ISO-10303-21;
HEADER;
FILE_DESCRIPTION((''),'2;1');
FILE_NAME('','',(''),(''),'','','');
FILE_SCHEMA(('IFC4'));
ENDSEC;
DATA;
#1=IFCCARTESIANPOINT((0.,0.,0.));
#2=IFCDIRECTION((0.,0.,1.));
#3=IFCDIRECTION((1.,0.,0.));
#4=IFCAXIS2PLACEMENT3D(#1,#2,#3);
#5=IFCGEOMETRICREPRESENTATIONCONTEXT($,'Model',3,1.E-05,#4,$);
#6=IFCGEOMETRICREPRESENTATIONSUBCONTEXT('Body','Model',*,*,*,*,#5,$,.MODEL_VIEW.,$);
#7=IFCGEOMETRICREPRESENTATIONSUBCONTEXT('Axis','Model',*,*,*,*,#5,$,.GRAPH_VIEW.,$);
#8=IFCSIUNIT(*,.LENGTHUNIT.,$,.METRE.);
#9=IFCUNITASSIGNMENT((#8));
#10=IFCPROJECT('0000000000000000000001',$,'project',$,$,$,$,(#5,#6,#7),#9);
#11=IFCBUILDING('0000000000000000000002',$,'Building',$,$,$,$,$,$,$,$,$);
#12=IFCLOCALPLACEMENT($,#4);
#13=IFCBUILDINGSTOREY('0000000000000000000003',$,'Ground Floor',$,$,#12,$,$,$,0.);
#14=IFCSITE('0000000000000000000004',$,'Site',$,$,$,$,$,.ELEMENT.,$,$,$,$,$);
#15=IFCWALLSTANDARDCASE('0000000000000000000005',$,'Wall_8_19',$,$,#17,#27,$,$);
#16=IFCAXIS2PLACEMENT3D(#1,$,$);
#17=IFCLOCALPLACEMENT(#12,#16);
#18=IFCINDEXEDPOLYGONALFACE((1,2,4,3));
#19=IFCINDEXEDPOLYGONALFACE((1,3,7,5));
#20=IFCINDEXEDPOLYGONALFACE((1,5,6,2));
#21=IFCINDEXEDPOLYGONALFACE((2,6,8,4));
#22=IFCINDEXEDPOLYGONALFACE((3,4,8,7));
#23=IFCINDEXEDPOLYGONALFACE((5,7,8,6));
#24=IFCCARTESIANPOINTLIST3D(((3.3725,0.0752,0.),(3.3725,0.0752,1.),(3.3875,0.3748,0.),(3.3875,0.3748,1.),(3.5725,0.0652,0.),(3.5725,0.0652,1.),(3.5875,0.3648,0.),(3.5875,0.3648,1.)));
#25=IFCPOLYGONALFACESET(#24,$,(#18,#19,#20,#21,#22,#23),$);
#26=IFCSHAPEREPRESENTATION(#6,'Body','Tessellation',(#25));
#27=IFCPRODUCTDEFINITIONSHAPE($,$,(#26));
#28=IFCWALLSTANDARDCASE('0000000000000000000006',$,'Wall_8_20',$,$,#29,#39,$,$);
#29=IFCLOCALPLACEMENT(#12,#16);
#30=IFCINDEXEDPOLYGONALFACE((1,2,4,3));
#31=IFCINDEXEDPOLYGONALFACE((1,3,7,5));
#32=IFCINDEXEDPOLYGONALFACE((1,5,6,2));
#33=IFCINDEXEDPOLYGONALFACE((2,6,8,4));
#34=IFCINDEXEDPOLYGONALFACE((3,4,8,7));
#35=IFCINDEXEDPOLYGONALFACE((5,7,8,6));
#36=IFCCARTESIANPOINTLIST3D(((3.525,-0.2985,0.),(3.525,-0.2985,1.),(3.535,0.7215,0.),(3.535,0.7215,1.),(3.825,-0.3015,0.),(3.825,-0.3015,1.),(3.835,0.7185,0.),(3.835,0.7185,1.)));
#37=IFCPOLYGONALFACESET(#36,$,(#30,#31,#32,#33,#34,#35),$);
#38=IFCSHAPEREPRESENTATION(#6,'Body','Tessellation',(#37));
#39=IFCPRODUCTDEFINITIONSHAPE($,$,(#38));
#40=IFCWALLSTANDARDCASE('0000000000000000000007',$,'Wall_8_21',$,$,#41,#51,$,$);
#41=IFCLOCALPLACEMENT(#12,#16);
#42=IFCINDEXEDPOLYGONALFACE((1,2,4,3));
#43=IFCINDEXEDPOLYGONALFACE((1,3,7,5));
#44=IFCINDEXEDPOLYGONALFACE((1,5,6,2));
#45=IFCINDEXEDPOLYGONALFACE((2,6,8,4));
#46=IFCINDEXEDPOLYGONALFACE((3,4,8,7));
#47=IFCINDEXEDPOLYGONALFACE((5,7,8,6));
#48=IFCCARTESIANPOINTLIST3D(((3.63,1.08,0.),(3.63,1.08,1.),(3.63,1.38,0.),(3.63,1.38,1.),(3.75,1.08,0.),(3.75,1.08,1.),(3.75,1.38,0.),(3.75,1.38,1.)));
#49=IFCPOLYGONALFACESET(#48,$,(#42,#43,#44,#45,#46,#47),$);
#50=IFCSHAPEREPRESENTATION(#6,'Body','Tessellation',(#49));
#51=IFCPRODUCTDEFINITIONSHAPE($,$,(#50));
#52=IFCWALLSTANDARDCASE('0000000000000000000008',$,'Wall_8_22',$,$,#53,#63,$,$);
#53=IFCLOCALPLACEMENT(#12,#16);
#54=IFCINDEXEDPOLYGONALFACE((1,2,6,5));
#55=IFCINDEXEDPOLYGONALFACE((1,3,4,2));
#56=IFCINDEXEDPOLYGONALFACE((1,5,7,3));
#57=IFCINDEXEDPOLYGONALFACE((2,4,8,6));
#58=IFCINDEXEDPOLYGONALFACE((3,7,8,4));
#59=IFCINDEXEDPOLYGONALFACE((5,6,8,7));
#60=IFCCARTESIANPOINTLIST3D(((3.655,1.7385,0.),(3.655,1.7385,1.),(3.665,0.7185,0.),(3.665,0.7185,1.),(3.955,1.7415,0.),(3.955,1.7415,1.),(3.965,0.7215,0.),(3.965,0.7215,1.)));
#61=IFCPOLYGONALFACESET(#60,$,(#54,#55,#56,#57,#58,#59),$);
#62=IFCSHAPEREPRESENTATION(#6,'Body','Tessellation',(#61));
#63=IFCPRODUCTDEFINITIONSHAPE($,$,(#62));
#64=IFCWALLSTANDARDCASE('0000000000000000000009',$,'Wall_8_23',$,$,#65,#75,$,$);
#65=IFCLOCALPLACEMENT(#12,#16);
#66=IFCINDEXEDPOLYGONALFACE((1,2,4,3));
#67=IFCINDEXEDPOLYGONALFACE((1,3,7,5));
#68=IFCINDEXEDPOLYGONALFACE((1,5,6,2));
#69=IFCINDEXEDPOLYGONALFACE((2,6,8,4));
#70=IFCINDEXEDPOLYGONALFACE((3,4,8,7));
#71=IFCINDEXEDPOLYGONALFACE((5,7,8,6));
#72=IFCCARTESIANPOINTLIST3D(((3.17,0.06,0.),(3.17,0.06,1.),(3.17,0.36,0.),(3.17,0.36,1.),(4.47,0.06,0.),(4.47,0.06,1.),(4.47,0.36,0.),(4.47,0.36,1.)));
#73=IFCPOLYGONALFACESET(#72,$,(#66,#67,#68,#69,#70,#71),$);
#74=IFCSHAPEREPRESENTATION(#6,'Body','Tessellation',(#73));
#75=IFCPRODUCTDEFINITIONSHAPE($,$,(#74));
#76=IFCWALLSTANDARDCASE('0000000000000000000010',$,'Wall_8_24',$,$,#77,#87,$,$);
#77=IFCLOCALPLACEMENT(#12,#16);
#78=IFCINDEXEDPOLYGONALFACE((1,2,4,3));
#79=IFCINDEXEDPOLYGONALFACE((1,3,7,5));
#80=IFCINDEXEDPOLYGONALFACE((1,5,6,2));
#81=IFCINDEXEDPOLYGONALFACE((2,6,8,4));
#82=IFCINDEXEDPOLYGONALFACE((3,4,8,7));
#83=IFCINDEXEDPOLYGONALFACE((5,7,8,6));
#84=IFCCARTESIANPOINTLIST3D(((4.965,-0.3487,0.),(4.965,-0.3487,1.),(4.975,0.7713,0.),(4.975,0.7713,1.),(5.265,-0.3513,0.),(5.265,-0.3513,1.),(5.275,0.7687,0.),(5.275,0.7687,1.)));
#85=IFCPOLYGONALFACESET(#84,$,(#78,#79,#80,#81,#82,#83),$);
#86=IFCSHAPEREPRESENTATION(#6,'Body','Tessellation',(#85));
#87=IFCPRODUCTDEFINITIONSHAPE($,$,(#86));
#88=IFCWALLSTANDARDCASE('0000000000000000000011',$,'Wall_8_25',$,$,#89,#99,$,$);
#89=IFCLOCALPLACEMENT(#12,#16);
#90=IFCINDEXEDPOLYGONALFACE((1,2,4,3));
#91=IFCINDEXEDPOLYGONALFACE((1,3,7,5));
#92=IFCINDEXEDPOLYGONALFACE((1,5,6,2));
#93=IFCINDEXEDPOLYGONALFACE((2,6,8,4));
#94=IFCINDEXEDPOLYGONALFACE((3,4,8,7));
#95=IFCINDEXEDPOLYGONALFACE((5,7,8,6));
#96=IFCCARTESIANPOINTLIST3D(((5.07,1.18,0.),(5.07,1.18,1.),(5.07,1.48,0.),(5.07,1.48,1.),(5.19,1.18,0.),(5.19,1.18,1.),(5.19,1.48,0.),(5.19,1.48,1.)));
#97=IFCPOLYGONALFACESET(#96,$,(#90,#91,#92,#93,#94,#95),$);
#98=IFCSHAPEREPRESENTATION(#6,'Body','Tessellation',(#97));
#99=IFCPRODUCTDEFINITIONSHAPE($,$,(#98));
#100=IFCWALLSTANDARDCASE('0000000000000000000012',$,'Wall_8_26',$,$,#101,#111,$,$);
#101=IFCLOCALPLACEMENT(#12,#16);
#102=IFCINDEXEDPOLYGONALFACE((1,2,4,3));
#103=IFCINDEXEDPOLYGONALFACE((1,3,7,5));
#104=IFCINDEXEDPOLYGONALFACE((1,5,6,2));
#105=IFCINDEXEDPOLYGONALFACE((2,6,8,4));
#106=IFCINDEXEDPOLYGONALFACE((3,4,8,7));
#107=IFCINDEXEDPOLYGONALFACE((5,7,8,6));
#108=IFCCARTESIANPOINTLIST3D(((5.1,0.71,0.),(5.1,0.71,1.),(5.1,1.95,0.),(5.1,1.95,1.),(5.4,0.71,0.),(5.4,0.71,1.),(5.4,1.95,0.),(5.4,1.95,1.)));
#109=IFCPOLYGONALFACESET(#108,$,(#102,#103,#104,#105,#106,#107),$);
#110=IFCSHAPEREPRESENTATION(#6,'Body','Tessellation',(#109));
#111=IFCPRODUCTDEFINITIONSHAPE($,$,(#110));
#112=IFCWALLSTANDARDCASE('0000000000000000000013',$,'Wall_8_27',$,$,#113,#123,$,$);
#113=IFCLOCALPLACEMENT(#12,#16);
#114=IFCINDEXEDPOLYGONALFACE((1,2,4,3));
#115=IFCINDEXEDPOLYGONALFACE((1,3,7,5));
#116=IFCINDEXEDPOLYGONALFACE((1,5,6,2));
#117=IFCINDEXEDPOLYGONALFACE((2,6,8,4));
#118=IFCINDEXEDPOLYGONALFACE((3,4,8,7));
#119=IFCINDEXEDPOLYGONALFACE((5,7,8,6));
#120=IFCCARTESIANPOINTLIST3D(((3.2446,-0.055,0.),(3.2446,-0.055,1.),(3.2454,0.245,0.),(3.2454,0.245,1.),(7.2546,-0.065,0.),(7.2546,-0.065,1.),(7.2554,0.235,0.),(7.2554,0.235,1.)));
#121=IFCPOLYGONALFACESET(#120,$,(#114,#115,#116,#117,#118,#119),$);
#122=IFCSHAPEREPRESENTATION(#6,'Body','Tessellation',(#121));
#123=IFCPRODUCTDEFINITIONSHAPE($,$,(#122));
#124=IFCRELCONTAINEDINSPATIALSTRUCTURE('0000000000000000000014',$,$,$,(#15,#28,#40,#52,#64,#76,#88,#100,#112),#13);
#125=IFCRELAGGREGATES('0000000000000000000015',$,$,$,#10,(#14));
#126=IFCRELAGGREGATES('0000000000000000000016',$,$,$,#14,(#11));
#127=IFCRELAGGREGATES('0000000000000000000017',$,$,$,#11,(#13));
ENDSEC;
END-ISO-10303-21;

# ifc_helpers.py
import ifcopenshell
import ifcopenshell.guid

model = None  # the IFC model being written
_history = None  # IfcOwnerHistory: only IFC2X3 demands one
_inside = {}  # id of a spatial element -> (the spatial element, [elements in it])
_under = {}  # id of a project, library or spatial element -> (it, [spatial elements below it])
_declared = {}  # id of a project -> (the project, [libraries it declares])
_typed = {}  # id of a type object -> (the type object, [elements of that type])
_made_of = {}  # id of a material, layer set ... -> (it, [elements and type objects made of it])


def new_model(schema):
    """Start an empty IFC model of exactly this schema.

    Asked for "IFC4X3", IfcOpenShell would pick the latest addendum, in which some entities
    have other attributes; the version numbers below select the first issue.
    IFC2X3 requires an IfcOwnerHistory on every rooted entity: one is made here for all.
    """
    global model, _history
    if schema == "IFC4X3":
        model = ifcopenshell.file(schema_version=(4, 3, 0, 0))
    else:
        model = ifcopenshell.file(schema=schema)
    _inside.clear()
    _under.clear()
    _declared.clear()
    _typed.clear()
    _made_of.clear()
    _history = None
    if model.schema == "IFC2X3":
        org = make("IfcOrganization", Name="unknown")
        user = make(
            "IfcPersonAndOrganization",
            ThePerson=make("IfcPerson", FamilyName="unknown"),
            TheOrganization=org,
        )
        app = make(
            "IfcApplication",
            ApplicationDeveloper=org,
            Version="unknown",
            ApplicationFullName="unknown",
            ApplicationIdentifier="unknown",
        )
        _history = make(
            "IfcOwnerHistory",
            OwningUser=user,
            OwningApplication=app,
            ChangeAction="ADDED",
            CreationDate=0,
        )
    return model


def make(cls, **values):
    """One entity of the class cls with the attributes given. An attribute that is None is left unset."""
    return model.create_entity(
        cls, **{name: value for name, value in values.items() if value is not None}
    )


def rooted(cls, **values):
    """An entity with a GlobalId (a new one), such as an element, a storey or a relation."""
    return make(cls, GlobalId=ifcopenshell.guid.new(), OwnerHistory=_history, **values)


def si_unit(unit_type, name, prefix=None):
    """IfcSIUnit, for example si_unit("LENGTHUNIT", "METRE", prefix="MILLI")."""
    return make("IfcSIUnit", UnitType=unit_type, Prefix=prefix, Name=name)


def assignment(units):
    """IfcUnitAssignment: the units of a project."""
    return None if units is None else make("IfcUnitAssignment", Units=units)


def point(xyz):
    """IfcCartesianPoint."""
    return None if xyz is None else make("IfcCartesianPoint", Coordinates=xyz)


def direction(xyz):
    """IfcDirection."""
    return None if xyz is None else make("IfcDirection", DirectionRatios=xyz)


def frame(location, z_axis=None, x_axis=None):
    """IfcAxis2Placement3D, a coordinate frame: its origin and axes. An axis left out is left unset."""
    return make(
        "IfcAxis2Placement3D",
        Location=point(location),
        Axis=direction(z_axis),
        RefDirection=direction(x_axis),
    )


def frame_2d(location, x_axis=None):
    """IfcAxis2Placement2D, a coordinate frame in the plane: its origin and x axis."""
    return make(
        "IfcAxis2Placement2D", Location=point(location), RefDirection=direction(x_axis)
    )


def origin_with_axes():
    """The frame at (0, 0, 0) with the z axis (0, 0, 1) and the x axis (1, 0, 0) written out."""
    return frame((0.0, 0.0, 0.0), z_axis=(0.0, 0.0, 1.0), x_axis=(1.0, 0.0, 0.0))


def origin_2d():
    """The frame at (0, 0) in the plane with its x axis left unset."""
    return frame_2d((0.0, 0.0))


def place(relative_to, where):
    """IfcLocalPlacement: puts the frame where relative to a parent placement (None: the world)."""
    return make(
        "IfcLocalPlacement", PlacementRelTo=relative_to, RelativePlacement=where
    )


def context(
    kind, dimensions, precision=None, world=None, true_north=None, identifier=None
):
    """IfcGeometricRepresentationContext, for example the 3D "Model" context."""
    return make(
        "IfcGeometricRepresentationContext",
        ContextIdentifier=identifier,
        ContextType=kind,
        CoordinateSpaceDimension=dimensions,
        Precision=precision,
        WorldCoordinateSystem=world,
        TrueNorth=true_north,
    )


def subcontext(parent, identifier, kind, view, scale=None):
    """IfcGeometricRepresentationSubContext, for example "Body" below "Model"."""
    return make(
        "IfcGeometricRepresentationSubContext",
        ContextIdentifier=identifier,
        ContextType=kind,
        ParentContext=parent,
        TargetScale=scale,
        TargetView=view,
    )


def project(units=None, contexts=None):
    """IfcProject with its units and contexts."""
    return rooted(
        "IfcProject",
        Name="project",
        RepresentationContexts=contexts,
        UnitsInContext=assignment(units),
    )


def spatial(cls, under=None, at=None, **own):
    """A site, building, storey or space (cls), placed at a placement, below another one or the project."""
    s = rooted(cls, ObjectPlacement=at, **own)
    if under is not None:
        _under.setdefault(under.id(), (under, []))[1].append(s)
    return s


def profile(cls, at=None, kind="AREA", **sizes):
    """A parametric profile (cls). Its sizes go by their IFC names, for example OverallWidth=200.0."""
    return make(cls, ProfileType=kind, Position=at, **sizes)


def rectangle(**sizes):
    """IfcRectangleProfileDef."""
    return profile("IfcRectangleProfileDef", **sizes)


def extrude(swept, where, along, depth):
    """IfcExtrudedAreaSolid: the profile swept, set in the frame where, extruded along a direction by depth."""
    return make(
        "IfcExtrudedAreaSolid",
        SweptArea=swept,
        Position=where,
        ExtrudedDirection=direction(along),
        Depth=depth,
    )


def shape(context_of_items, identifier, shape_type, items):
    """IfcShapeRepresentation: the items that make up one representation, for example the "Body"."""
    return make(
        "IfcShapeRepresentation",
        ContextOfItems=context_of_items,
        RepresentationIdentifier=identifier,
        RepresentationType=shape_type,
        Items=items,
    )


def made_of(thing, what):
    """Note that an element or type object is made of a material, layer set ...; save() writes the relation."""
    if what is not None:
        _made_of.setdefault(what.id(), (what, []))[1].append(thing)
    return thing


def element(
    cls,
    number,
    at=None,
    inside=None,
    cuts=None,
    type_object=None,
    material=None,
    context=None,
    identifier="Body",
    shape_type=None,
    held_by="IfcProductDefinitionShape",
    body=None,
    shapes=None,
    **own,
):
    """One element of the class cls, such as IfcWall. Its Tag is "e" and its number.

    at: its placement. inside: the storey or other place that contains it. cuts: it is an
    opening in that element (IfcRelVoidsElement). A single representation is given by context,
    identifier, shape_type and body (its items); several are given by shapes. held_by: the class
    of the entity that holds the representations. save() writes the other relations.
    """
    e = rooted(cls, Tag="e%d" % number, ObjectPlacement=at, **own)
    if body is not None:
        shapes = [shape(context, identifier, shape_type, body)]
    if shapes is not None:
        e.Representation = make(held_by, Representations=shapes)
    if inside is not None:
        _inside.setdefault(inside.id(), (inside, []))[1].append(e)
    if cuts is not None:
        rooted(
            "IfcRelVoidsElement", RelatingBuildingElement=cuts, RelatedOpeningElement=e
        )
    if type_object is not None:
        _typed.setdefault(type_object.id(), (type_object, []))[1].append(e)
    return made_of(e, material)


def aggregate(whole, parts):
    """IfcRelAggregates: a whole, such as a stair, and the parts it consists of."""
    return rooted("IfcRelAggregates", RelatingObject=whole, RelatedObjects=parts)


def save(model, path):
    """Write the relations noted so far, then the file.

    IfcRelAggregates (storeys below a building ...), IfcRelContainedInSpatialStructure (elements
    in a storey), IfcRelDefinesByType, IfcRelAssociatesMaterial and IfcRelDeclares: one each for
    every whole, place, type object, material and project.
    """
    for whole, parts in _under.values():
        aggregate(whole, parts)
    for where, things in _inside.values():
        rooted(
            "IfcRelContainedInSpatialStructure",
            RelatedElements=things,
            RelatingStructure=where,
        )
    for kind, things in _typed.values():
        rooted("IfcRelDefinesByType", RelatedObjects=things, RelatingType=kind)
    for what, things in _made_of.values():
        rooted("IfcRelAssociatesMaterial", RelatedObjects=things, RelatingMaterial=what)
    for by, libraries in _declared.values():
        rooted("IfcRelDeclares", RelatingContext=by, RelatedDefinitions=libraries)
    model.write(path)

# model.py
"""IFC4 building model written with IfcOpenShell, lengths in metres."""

from ifc_helpers import new_model, si_unit, frame, origin_with_axes, origin_2d, place, context, subcontext, project, spatial, rectangle, extrude, element, save


model = new_model("IFC4")

# Units and contexts
model_context = context("Model", 3, precision=1e-05, world=origin_with_axes())
body_context = subcontext(model_context, "Body", "Model", "MODEL_VIEW")
axis_context = subcontext(model_context, "Axis", "Model", "GRAPH_VIEW")
ifc_project = project(units=[si_unit("LENGTHUNIT", "METRE")], contexts=[model_context, body_context, axis_context])

# Site, building, storey
site = spatial("IfcSite", under=ifc_project, Name="Site", CompositionType="ELEMENT")
building = spatial("IfcBuilding", under=site, Name="Building")
storey_placement = place(None, origin_with_axes())
storey = spatial("IfcBuildingStorey", under=building, at=storey_placement, Name="Ground Floor", Elevation=0.0)

# Walls
wall_1_placement = place(storey_placement, frame((3.48, 0.22, 0.0), z_axis=(0.0, 0.0, 1.0), x_axis=(0.998752, -0.049938, 0.0)))
element("IfcWallStandardCase", 1, at=wall_1_placement, inside=storey, Name="Wall_8_19", context=body_context, shape_type="SweptSolid", body=[
    extrude(rectangle(XDim=0.2002, YDim=0.3, at=origin_2d()), origin_with_axes(), (0.0, 0.0, 1.0), 1.0),
])
wall_2_placement = place(storey_placement, frame((3.68, 0.21, 0.0), z_axis=(0.0, 0.0, 1.0), x_axis=(0.009803, 0.999952, 0.0)))
element("IfcWallStandardCase", 2, at=wall_2_placement, inside=storey, Name="Wall_8_20", context=body_context, shape_type="SweptSolid", body=[
    extrude(rectangle(XDim=1.02, YDim=0.3, at=origin_2d()), origin_with_axes(), (0.0, 0.0, 1.0), 1.0),
])
wall_3_placement = place(storey_placement, frame((3.69, 1.23, 0.0), z_axis=(0.0, 0.0, 1.0), x_axis=(1.0, 0.0, 0.0)))
element("IfcWallStandardCase", 3, at=wall_3_placement, inside=storey, Name="Wall_8_21", context=body_context, shape_type="SweptSolid", body=[
    extrude(rectangle(XDim=0.12, YDim=0.3, at=origin_2d()), origin_with_axes(), (0.0, 0.0, 1.0), 1.0),
])
wall_4_placement = place(storey_placement, frame((3.81, 1.23, 0.0), z_axis=(0.0, 0.0, 1.0), x_axis=(0.009803, -0.999952, 0.0)))
element("IfcWallStandardCase", 4, at=wall_4_placement, inside=storey, Name="Wall_8_22", context=body_context, shape_type="SweptSolid", body=[
    extrude(rectangle(XDim=1.02, YDim=0.3, at=origin_2d()), origin_with_axes(), (0.0, 0.0, 1.0), 1.0),
])
wall_5_placement = place(storey_placement, frame((3.82, 0.21, 0.0), z_axis=(0.0, 0.0, 1.0), x_axis=(1.0, 0.0, 0.0)))
element("IfcWallStandardCase", 5, at=wall_5_placement, inside=storey, Name="Wall_8_23", context=body_context, shape_type="SweptSolid", body=[
    extrude(rectangle(XDim=1.3, YDim=0.3, at=origin_2d()), origin_with_axes(), (0.0, 0.0, 1.0), 1.0),
])
wall_6_placement = place(storey_placement, frame((5.12, 0.21, 0.0), z_axis=(0.0, 0.0, 1.0), x_axis=(0.008928, 0.99996, 0.0)))
element("IfcWallStandardCase", 6, at=wall_6_placement, inside=storey, Name="Wall_8_24", context=body_context, shape_type="SweptSolid", body=[
    extrude(rectangle(XDim=1.12, YDim=0.3, at=origin_2d()), origin_with_axes(), (0.0, 0.0, 1.0), 1.0),
])
wall_7_placement = place(storey_placement, frame((5.13, 1.33, 0.0), z_axis=(0.0, 0.0, 1.0), x_axis=(1.0, 0.0, 0.0)))
element("IfcWallStandardCase", 7, at=wall_7_placement, inside=storey, Name="Wall_8_25", context=body_context, shape_type="SweptSolid", body=[
    extrude(rectangle(XDim=0.12, YDim=0.3, at=origin_2d()), origin_with_axes(), (0.0, 0.0, 1.0), 1.0),
])
wall_8_placement = place(storey_placement, frame((5.25, 1.33, 0.0), z_axis=(0.0, 0.0, 1.0), x_axis=(0.0, -1.0, 0.0)))
element("IfcWallStandardCase", 8, at=wall_8_placement, inside=storey, Name="Wall_8_26", context=body_context, shape_type="SweptSolid", body=[
    extrude(rectangle(XDim=1.24, YDim=0.3, at=origin_2d()), origin_with_axes(), (0.0, 0.0, 1.0), 1.0),
])
wall_9_placement = place(storey_placement, frame((5.25, 0.09, 0.0), z_axis=(0.0, 0.0, 1.0), x_axis=(-0.999997, 0.002494, 0.0)))
element("IfcWallStandardCase", 9, at=wall_9_placement, inside=storey, Name="Wall_8_27", context=body_context, shape_type="SweptSolid", body=[
    extrude(rectangle(XDim=4.01, YDim=0.3, at=origin_2d()), origin_with_axes(), (0.0, 0.0, 1.0), 1.0),
])

save(model, "model.ifc")
